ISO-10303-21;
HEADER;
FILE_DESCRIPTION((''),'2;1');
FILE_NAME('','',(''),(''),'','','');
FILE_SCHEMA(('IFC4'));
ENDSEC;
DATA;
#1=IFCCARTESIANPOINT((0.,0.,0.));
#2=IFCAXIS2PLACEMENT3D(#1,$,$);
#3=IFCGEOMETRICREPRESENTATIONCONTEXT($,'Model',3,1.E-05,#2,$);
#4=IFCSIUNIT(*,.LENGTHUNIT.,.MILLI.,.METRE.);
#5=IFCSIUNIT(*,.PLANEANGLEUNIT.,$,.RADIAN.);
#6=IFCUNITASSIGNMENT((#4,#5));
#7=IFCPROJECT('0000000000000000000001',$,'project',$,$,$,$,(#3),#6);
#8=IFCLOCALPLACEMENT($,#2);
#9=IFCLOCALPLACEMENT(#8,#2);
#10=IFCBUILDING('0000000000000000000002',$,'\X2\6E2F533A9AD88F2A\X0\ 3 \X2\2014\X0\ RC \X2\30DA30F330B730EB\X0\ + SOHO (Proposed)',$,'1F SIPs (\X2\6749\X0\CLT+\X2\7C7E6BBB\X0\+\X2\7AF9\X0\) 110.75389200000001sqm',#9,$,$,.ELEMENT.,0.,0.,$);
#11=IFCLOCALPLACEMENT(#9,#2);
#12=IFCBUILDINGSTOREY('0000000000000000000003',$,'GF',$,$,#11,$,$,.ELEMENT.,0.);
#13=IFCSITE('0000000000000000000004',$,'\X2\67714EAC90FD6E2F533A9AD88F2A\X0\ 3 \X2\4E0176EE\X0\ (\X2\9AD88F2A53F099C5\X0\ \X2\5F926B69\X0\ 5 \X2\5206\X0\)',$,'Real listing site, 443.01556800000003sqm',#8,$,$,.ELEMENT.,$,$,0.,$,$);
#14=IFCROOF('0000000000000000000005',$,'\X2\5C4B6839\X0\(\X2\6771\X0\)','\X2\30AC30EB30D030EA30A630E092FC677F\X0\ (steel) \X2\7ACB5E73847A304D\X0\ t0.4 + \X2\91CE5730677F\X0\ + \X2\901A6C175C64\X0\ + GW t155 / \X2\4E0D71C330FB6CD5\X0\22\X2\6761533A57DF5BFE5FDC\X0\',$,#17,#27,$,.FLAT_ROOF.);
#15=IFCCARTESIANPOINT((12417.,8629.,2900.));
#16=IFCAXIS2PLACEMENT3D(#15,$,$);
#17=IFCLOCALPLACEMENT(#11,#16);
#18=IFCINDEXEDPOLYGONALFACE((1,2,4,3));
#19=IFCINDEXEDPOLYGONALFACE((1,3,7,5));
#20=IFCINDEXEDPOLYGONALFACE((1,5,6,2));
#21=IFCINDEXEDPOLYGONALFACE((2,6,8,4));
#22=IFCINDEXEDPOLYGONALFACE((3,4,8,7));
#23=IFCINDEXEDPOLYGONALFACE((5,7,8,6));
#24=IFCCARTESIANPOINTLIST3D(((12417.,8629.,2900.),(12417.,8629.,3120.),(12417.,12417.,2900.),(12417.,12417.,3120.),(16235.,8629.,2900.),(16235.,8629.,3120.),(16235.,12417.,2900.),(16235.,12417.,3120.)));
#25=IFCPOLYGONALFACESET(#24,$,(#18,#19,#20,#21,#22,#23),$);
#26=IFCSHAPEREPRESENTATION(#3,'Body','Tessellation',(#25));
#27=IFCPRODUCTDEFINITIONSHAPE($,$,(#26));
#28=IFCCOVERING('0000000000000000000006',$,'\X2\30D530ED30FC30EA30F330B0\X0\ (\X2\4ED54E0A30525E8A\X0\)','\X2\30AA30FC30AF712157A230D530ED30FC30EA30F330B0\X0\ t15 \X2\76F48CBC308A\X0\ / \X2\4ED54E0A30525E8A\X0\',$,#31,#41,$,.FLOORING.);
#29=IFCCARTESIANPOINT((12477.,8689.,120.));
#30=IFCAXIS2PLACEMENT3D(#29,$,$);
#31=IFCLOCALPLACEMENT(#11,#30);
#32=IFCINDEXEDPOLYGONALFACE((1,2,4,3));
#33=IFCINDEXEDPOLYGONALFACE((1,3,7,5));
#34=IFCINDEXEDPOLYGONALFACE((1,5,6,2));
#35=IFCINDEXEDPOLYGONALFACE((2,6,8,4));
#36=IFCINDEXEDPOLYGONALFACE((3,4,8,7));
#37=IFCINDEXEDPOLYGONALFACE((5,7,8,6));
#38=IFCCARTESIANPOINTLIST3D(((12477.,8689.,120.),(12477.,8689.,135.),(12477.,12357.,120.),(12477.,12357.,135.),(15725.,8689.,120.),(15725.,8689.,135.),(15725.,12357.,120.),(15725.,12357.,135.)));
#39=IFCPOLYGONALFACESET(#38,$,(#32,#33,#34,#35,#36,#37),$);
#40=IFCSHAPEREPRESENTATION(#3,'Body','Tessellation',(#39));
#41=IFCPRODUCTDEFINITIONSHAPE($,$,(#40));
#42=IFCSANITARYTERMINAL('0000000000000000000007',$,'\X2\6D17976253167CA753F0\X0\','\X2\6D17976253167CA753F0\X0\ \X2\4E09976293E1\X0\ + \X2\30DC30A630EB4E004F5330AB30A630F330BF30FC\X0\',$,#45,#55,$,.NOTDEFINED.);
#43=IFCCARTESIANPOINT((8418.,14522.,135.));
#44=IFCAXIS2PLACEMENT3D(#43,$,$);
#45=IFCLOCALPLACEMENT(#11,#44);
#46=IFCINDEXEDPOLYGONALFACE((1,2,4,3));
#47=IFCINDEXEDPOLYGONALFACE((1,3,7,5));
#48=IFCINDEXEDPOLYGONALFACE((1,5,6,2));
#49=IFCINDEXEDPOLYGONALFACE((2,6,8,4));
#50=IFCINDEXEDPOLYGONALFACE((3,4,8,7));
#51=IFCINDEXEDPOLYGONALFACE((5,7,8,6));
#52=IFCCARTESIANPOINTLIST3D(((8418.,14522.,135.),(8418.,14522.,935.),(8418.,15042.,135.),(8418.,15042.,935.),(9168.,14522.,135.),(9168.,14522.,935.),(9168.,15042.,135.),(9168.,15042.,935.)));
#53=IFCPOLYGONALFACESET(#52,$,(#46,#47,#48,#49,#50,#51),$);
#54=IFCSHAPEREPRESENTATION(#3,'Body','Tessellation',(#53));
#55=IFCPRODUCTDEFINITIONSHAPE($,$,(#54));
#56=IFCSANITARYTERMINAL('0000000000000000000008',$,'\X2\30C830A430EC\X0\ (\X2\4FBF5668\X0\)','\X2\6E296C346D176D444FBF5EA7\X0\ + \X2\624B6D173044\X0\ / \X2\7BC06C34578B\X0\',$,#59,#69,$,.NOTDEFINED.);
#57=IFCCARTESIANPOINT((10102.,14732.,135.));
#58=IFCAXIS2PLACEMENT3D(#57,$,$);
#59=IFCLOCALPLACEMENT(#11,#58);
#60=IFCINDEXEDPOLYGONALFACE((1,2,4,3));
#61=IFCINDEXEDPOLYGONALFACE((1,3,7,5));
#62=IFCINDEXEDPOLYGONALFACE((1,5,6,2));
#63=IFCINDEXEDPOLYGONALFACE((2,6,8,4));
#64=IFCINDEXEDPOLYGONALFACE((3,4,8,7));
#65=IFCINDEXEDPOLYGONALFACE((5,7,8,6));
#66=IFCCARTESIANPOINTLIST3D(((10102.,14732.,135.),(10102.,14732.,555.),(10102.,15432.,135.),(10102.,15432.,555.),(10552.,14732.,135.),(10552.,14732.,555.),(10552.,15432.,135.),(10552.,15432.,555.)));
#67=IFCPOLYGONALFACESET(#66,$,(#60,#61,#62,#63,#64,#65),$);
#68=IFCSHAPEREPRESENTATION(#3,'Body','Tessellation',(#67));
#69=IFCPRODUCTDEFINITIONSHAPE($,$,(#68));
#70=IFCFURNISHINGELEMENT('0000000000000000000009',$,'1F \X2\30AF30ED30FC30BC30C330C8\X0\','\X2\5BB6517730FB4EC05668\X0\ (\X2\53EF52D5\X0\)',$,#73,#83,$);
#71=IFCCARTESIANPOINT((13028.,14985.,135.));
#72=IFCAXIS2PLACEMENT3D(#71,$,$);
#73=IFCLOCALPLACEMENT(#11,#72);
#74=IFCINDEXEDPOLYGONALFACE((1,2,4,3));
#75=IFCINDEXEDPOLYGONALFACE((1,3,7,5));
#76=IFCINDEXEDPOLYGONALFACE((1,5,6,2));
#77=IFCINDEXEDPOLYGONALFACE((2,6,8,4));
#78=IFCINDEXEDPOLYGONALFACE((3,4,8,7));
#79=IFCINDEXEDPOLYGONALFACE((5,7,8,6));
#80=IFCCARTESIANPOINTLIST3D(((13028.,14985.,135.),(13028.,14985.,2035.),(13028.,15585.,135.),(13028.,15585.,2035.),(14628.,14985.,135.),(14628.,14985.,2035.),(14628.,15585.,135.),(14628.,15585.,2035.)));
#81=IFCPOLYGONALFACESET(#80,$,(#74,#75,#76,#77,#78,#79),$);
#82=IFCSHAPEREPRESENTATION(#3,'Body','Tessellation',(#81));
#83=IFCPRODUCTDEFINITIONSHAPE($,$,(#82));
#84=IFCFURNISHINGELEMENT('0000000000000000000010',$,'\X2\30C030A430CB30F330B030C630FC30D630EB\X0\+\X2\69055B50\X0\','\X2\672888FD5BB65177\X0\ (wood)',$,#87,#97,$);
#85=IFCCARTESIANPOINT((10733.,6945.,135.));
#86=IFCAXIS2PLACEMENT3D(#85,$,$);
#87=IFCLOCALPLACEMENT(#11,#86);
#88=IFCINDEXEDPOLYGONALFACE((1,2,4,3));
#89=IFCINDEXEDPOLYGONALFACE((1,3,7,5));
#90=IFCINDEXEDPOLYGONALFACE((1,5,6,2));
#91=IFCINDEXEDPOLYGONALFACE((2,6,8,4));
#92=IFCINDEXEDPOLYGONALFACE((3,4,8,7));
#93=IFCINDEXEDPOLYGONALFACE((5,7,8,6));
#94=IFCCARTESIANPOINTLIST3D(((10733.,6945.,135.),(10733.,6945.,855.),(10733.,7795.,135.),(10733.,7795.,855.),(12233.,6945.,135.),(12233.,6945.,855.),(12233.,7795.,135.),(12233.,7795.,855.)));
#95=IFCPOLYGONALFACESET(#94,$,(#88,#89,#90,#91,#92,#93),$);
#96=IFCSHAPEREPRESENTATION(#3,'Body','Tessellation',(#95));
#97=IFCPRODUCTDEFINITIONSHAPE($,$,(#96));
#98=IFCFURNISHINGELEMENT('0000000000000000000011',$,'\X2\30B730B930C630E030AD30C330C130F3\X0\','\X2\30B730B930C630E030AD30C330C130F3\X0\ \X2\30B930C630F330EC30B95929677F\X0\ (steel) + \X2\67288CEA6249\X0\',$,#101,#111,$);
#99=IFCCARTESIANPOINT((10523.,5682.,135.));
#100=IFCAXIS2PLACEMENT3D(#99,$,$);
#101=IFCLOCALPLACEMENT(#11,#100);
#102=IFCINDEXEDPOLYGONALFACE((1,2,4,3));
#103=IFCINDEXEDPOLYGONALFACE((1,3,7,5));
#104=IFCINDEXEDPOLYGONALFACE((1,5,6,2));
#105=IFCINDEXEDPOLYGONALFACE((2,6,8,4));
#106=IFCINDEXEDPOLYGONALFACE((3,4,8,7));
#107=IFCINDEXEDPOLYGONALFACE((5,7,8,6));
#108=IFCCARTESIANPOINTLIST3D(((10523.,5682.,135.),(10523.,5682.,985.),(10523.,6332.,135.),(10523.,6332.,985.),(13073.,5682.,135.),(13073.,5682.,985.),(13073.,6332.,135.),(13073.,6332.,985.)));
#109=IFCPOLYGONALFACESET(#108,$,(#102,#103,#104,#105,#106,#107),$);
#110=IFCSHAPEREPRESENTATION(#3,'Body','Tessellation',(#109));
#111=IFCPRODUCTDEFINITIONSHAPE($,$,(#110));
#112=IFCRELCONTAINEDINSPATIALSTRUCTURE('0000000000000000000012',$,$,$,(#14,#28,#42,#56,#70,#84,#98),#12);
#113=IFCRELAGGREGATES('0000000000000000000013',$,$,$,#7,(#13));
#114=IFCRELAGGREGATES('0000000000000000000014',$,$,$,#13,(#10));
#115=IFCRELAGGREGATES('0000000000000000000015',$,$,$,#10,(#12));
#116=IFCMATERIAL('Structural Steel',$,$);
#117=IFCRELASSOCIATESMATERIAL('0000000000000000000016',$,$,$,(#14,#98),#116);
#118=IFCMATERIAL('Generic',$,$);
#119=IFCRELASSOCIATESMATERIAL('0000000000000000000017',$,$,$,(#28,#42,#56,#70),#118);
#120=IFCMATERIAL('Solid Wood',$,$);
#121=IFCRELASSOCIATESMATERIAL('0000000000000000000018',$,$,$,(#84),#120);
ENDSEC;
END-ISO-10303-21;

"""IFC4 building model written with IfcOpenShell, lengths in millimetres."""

from ifc_helpers import new_model, si_unit, frame, frame_2d, origin, place, context, project, spatial, rectangle, extrude, material, element, save


model = new_model("IFC4")

# Units and contexts
model_context = context("Model", 3, precision=1e-05, world=origin())
ifc_project = project(units=[si_unit("LENGTHUNIT", "METRE", prefix="MILLI"), si_unit("PLANEANGLEUNIT", "RADIAN")], contexts=[model_context])

# Site, building, storey
site_placement = place(None, origin())
site = spatial("IfcSite", under=ifc_project, at=site_placement, Name="東京都港区高輪 3 丁目 (高輪台駅 徒歩 5 分)", ObjectType="Real listing site, 443.01556800000003sqm", CompositionType="ELEMENT", RefElevation=0.0)
building_placement = place(site_placement, origin())
building = spatial("IfcBuilding", under=site, at=building_placement, Name="港区高輪 3 — RC ペンシル + SOHO (Proposed)", ObjectType="1F SIPs (杉CLT+籾殻+竹) 110.75389200000001sqm", CompositionType="ELEMENT", ElevationOfRefHeight=0.0, ElevationOfTerrain=0.0)
storey_placement = place(building_placement, origin())
storey = spatial("IfcBuildingStorey", under=building, at=storey_placement, Name="GF", CompositionType="ELEMENT", Elevation=0.0)

# Shared definitions
ifc_material_1 = material(Name="Solid Wood")

# Roof
ifc_material_2 = material(Name="Structural Steel")
roof_placement = place(storey_placement, frame((12417.0, 8629.0, 2900.0)))
element("IfcRoof", 1, at=roof_placement, inside=storey, material=ifc_material_2, Name="屋根(東)", Description="ガルバリウム鋼板 (steel) 立平葺き t0.4 + 野地板 + 通気層 + GW t155 / 不燃・法22条区域対応", PredefinedType="FLAT_ROOF", context=model_context, shape_type="SweptSolid", body=[
    extrude(rectangle(XDim=3818.0, YDim=3788.0, at=frame_2d((1909.0, 1894.0))), frame((12417.0, 8629.0, 2900.0)), (0.0, 0.0, 1.0), 220.0),
])

# Covering
ifc_material_3 = material(Name="Generic")
covering_placement = place(storey_placement, frame((12477.0, 8689.0, 120.0)))
element("IfcCovering", 2, at=covering_placement, inside=storey, material=ifc_material_3, Name="フローリング (仕上げ床)", Description="オーク無垢フローリング t15 直貼り / 仕上げ床", PredefinedType="FLOORING", context=model_context, shape_type="SweptSolid", body=[
    extrude(rectangle(XDim=3248.0, YDim=3668.0, at=frame_2d((1624.0, 1834.0))), frame((12477.0, 8689.0, 120.0)), (0.0, 0.0, 1.0), 15.0),
])

# Sanitary terminals
sanitary_terminal_1_placement = place(storey_placement, frame((8418.0, 14522.0, 135.0)))
element("IfcSanitaryTerminal", 3, at=sanitary_terminal_1_placement, inside=storey, material=ifc_material_3, Name="洗面化粧台", Description="洗面化粧台 三面鏡 + ボウル一体カウンター", PredefinedType="NOTDEFINED", context=model_context, shape_type="SweptSolid", body=[
    extrude(rectangle(XDim=750.0, YDim=520.0, at=frame_2d((375.0, 260.0))), frame((8418.0, 14522.0, 135.0)), (0.0, 0.0, 1.0), 800.0),
])
sanitary_terminal_2_placement = place(storey_placement, frame((10102.0, 14732.0, 135.0)))
element("IfcSanitaryTerminal", 4, at=sanitary_terminal_2_placement, inside=storey, material=ifc_material_3, Name="トイレ (便器)", Description="温水洗浄便座 + 手洗い / 節水型", PredefinedType="NOTDEFINED", context=model_context, shape_type="SweptSolid", body=[
    extrude(rectangle(XDim=450.0, YDim=700.0, at=frame_2d((225.0, 350.0))), frame((10102.0, 14732.0, 135.0)), (0.0, 0.0, 1.0), 420.0),
])

# Furnishing elements
furnishing_1_placement = place(storey_placement, frame((13028.0, 14985.0, 135.0)))
element("IfcFurnishingElement", 5, at=furnishing_1_placement, inside=storey, material=ifc_material_3, Name="1F クローゼット", Description="家具・什器 (可動)", context=model_context, shape_type="SweptSolid", body=[
    extrude(rectangle(XDim=1600.0, YDim=600.0, at=frame_2d((800.0, 300.0))), frame((13028.0, 14985.0, 135.0)), (0.0, 0.0, 1.0), 1900.0),
])
furnishing_2_placement = place(storey_placement, frame((10733.0, 6945.0, 135.0)))
element("IfcFurnishingElement", 6, at=furnishing_2_placement, inside=storey, material=ifc_material_1, Name="ダイニングテーブル+椅子", Description="木製家具 (wood)", context=model_context, shape_type="SweptSolid", body=[
    extrude(rectangle(XDim=1500.0, YDim=850.0, at=frame_2d((750.0, 425.0))), frame((10733.0, 6945.0, 135.0)), (0.0, 0.0, 1.0), 720.0),
])
furnishing_3_placement = place(storey_placement, frame((10523.0, 5682.0, 135.0)))
element("IfcFurnishingElement", 7, at=furnishing_3_placement, inside=storey, material=ifc_material_2, Name="システムキッチン", Description="システムキッチン ステンレス天板 (steel) + 木質扉", context=model_context, shape_type="SweptSolid", body=[
    extrude(rectangle(XDim=2550.0, YDim=650.0, at=frame_2d((1275.0, 325.0))), frame((10523.0, 5682.0, 135.0)), (0.0, 0.0, 1.0), 850.0),
])

save(model, "model.ifc")
